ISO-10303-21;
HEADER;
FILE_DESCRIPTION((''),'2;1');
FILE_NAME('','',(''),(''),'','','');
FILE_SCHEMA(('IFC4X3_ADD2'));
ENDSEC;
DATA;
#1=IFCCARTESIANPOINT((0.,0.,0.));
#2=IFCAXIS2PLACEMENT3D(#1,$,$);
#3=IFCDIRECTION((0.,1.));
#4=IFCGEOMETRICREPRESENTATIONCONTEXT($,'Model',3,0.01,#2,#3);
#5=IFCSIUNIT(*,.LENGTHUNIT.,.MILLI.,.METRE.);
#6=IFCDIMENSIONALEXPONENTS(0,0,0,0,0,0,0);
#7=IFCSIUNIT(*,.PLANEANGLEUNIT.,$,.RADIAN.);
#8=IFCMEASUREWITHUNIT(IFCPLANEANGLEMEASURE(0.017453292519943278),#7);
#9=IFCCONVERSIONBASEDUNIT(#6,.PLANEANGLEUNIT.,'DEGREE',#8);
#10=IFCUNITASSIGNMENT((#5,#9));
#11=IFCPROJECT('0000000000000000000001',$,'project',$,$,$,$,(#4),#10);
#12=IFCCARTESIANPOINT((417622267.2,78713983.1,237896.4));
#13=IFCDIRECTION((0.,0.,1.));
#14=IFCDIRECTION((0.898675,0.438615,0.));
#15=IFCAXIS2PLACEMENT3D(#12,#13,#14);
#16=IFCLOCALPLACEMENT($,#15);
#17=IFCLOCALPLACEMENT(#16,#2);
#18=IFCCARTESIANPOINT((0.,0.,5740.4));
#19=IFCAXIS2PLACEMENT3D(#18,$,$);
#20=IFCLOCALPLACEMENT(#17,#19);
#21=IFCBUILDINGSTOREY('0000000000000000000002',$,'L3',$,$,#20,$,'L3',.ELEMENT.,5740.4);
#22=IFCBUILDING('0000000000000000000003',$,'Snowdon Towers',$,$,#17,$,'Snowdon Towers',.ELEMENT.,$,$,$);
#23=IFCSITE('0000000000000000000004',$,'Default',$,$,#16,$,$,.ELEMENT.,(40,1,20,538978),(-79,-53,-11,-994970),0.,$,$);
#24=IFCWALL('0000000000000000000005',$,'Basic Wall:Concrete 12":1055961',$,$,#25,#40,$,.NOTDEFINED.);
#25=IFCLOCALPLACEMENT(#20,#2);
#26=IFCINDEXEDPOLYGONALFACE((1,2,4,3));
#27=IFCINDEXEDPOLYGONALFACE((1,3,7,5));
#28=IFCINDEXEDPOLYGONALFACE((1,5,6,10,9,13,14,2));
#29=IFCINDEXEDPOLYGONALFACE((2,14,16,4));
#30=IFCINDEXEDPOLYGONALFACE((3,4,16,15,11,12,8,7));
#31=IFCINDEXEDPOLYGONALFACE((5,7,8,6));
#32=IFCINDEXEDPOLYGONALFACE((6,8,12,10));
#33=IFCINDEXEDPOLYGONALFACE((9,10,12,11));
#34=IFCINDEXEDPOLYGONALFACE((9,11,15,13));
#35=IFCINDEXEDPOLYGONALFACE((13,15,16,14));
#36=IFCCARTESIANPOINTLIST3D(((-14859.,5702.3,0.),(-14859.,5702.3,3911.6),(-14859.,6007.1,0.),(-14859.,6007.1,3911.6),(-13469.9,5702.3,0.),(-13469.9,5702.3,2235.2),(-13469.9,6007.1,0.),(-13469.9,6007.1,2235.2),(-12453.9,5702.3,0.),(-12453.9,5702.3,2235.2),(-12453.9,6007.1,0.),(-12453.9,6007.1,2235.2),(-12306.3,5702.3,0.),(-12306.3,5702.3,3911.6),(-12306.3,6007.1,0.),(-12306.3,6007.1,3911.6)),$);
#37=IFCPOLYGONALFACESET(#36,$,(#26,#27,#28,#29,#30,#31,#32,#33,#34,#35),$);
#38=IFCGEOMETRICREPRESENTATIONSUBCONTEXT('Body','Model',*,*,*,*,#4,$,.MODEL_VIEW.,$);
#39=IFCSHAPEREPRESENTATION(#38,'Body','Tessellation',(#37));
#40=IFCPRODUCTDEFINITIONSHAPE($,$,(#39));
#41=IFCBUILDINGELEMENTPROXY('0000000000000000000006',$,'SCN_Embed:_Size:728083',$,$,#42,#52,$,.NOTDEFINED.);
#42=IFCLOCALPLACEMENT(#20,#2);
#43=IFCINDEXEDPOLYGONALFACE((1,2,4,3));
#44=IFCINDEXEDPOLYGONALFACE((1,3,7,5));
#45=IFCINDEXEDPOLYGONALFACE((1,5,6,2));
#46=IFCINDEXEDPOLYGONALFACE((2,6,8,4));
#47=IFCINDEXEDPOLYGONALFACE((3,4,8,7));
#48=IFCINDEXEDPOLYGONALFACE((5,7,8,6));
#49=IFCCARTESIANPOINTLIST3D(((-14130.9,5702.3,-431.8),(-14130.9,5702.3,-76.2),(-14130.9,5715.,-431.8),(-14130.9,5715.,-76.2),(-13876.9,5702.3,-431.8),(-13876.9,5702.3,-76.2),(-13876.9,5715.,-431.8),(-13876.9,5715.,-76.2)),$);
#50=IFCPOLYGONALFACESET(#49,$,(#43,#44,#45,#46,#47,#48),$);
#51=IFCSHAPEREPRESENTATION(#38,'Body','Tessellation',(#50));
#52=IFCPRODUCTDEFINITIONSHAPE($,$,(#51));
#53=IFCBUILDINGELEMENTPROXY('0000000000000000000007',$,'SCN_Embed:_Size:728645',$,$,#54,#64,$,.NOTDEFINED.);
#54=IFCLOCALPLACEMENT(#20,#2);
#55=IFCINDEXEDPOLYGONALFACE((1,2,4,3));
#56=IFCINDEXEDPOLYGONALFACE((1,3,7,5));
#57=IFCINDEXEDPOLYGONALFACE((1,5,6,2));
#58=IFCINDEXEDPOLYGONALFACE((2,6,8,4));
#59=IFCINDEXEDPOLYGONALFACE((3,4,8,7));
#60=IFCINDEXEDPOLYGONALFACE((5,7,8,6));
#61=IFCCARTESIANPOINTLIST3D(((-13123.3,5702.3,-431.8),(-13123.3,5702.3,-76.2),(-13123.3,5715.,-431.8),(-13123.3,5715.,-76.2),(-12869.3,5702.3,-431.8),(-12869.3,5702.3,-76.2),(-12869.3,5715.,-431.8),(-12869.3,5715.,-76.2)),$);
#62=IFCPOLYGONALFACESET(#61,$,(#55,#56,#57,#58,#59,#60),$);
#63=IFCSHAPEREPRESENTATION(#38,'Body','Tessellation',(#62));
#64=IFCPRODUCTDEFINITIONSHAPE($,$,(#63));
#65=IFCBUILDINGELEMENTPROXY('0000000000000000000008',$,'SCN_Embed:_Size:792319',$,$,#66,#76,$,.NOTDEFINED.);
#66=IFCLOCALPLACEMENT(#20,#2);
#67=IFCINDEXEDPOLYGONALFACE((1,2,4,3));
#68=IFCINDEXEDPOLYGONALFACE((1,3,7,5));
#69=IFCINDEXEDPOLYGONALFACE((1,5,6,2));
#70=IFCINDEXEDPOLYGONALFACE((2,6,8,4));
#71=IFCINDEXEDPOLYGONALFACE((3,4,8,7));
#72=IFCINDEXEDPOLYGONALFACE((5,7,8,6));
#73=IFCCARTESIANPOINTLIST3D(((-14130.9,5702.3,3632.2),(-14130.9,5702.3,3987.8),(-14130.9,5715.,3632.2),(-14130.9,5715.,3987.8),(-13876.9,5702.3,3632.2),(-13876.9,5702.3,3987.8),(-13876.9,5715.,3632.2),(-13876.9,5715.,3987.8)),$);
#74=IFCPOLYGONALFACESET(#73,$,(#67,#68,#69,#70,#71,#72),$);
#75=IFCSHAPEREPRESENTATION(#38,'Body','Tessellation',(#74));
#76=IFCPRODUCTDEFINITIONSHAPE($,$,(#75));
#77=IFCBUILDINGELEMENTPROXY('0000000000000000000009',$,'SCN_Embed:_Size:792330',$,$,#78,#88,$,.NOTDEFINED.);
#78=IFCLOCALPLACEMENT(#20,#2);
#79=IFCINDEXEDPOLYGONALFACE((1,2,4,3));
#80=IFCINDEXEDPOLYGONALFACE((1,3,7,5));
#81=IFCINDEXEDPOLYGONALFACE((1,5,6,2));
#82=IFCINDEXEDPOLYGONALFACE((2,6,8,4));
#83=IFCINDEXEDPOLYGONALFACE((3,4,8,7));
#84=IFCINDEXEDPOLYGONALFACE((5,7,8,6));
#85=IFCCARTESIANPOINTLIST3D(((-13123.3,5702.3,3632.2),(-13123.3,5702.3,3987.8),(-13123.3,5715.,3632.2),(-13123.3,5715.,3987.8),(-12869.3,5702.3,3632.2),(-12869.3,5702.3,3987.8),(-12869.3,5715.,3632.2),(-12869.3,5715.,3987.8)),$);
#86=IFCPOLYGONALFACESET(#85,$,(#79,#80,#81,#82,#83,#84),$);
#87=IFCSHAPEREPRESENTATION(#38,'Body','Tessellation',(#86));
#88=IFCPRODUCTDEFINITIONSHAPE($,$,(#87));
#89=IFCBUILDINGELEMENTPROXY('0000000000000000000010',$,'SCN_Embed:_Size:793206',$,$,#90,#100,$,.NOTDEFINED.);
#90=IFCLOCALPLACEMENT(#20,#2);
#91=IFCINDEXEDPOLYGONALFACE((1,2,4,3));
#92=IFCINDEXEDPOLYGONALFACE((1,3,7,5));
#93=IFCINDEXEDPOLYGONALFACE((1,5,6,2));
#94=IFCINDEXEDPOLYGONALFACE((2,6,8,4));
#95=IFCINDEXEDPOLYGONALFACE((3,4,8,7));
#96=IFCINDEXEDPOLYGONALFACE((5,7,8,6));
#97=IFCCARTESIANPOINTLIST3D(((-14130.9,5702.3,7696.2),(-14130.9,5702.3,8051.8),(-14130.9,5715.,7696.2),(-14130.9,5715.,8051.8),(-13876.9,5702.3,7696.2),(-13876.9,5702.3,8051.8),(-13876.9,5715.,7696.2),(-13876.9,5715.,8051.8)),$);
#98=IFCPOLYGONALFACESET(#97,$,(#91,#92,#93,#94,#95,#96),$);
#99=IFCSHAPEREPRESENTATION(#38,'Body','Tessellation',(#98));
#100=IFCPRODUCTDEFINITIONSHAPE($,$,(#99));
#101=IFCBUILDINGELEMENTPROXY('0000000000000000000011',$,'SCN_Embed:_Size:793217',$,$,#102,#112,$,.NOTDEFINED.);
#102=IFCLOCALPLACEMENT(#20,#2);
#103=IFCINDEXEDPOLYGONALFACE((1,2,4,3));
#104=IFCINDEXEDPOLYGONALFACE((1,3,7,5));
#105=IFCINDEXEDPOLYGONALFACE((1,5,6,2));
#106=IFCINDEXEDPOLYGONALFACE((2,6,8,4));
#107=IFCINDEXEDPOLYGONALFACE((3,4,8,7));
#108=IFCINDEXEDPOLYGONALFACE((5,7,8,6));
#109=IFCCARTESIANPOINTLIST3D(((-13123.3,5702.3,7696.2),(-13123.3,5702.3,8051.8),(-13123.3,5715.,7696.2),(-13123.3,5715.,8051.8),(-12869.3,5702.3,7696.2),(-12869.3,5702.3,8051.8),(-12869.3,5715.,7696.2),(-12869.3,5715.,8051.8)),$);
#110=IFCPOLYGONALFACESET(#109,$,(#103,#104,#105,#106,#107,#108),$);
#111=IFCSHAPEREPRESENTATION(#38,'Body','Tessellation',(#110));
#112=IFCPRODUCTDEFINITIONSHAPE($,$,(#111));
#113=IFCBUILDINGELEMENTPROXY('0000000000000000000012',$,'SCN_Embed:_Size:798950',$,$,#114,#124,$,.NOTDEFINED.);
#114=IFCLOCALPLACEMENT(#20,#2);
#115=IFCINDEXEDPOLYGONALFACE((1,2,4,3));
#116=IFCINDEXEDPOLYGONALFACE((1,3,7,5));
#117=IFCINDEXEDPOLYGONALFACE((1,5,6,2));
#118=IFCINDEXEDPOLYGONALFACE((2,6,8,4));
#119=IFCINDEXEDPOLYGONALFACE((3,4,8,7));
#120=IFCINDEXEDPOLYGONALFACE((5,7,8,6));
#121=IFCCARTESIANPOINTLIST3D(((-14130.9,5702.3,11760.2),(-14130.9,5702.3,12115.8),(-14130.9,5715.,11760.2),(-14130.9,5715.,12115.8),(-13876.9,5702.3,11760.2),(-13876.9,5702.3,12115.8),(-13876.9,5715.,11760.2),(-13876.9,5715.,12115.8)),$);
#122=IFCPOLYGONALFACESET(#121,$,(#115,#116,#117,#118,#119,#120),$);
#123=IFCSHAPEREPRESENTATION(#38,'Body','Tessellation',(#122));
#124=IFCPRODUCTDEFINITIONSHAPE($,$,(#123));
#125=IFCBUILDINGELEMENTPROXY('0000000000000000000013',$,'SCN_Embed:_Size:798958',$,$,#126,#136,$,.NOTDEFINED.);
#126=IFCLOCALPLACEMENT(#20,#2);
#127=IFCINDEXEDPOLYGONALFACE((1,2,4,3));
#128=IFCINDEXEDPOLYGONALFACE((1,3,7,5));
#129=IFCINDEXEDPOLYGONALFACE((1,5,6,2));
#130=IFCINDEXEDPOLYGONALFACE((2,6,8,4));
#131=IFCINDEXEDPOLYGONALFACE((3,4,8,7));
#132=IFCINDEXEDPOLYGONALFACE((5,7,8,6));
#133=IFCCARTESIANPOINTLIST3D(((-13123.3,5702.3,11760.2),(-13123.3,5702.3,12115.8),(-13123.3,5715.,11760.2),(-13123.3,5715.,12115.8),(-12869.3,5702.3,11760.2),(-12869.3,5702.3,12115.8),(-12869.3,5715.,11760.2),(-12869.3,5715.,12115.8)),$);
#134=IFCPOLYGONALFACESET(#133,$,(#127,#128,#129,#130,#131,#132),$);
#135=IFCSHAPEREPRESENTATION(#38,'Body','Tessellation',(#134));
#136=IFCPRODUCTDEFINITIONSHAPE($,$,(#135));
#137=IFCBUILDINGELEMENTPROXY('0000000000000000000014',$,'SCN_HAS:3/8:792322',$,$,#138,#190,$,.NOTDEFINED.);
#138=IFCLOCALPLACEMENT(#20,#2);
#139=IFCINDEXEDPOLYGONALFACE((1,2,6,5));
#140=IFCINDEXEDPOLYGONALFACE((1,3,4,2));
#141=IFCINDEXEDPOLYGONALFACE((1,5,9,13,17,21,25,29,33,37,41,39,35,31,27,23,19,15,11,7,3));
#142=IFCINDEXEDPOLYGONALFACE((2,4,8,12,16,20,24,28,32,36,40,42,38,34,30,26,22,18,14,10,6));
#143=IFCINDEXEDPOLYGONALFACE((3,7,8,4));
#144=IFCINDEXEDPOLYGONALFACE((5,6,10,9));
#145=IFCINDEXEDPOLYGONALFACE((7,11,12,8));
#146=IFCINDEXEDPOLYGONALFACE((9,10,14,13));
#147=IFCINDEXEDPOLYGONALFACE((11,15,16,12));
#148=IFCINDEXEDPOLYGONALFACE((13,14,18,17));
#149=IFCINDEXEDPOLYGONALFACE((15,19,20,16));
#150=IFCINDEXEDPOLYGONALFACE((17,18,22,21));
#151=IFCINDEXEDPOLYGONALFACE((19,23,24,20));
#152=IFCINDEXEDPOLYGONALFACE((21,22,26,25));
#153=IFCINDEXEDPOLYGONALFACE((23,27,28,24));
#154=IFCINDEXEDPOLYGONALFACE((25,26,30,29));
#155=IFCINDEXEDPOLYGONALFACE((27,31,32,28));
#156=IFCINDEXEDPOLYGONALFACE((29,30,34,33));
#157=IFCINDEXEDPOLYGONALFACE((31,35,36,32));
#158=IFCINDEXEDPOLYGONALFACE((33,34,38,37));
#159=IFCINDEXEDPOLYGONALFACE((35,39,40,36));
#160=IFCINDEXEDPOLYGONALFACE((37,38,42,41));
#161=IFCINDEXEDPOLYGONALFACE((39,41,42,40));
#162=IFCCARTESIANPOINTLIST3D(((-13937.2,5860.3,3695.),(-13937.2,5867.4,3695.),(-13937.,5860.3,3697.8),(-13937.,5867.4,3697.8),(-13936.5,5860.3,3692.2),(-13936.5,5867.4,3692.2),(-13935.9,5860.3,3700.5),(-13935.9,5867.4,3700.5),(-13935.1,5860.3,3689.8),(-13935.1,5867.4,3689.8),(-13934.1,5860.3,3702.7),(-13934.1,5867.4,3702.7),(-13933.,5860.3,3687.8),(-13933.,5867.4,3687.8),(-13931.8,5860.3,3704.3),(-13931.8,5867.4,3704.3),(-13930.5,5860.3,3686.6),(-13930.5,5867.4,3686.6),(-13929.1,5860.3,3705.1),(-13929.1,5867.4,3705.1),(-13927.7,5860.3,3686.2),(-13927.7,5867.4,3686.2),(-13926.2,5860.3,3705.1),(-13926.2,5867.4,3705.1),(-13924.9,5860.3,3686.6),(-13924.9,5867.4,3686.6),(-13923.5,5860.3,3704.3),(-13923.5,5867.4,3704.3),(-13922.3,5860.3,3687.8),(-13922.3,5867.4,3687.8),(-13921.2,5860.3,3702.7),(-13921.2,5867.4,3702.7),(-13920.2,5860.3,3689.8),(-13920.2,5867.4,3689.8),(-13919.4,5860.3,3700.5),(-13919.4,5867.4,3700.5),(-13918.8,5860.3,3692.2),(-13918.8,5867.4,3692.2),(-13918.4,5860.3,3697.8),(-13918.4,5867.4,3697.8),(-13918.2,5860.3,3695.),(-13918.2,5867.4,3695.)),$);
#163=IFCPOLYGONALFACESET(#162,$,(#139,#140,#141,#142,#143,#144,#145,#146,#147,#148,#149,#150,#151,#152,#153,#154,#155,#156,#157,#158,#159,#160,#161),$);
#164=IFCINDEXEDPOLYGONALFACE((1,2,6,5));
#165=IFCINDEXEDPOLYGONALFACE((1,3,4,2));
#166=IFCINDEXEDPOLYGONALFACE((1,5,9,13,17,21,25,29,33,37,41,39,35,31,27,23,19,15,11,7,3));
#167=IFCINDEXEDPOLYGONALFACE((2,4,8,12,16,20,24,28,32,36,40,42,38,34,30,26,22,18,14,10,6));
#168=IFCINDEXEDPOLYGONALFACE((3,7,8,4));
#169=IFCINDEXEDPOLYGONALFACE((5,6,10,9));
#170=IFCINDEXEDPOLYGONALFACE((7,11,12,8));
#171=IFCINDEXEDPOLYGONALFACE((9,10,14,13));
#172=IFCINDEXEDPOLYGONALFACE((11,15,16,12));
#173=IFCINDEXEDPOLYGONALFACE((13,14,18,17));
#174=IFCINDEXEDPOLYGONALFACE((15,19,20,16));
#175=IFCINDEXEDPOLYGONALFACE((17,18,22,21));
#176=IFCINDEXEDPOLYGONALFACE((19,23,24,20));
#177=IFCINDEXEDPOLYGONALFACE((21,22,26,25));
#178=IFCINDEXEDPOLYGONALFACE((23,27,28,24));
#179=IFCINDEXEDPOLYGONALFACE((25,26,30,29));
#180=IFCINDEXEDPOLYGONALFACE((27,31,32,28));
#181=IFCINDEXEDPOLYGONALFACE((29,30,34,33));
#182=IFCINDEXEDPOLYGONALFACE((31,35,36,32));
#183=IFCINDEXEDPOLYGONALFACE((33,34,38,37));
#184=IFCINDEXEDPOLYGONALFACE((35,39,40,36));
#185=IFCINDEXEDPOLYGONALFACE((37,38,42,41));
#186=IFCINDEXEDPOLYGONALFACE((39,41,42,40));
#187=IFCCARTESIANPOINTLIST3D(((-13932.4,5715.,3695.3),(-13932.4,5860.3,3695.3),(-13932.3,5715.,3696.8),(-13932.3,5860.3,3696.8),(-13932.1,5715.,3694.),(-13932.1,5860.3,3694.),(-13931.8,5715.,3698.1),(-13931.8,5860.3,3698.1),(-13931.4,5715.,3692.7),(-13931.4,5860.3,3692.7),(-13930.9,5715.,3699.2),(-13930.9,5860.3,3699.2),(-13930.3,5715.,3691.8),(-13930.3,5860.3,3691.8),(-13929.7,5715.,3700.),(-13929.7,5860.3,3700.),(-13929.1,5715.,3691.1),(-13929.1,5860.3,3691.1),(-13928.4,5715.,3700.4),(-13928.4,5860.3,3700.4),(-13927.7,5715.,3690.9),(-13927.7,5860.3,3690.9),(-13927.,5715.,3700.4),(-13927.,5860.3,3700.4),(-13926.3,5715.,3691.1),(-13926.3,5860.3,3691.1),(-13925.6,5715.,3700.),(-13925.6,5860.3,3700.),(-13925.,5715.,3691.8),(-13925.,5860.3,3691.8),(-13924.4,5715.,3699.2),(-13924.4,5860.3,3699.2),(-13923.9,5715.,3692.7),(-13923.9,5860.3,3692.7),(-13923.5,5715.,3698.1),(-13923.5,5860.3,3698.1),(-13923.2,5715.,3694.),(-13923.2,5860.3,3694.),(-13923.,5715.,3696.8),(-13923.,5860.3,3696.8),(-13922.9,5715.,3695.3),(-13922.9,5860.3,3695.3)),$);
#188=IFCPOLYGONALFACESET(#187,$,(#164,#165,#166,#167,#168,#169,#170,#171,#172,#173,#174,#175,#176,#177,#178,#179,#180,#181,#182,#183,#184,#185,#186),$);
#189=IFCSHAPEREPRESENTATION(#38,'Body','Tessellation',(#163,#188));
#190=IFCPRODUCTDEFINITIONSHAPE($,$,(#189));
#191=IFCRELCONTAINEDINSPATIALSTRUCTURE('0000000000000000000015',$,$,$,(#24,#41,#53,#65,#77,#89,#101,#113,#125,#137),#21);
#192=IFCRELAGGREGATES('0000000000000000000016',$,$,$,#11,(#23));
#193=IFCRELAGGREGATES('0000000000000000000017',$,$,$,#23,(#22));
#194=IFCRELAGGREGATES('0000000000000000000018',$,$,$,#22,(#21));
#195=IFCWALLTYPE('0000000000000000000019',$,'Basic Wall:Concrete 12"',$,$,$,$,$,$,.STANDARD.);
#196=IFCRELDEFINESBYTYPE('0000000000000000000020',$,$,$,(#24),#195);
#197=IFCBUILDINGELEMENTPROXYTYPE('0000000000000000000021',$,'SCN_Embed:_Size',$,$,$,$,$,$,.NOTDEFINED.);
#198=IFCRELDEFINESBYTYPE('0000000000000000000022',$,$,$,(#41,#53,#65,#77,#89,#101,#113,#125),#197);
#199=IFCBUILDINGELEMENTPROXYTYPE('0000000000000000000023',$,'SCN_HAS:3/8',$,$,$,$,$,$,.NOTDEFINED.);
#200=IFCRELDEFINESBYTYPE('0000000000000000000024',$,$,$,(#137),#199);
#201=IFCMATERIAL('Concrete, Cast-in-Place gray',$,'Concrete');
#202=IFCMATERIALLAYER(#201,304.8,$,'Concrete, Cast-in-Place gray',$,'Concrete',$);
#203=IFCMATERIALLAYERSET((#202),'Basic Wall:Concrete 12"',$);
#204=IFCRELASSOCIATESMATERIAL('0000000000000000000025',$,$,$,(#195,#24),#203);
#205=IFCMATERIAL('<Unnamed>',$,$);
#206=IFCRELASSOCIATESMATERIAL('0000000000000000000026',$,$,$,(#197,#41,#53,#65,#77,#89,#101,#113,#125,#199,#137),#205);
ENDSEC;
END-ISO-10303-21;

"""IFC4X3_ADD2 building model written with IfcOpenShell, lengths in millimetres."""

from ifc_helpers import new_model, entity, si_unit, converted_unit, direction, frame, frame_2d, origin, place, context, subcontext, project, spatial, rectangle, circle, extrude, source, transform, mapped, material, layer, layer_set, type_object, type_shapes, element, save


model = new_model("IFC4X3_ADD2")

# Units and contexts
model_context = context("Model", 3, precision=0.01, world=origin(), true_north=direction((0.0, 1.0)))
body_context = subcontext(model_context, "Body", "Model", "MODEL_VIEW")
ifc_project = project(units=[si_unit("LENGTHUNIT", "METRE", prefix="MILLI"), converted_unit("PLANEANGLEUNIT", "DEGREE", entity("IfcPlaneAngleMeasure", 0.017453292519943278), si_unit("PLANEANGLEUNIT", "RADIAN"), dimensions=[0, 0, 0, 0, 0, 0, 0])], contexts=[model_context])

# Site, building, storey
site_placement = place(None, frame((417622267.2, 78713983.1, 237896.4), z_axis=(0.0, 0.0, 1.0), x_axis=(0.898675, 0.438615, 0.0)))
site = spatial("IfcSite", under=ifc_project, at=site_placement, Name="Default", CompositionType="ELEMENT", RefLatitude=(40, 1, 20, 538978), RefLongitude=(-79, -53, -11, -994970), RefElevation=0.0)
building_placement = place(site_placement, origin())
building = spatial("IfcBuilding", under=site, at=building_placement, Name="Snowdon Towers", LongName="Snowdon Towers", CompositionType="ELEMENT")
storey_placement = place(building_placement, frame((0.0, 0.0, 5740.4)))
storey = spatial("IfcBuildingStorey", under=building, at=storey_placement, Name="L3", LongName="L3", CompositionType="ELEMENT", Elevation=5740.4)

# Shared definitions
ifc_material_1 = material(Name="Concrete, Cast-in-Place gray", Category="Concrete")
ifc_layer = layer(ifc_material_1, 304.8, Name="Concrete, Cast-in-Place gray", Category="Concrete")
ifc_layer_set = layer_set([ifc_layer], Name="Basic Wall:Concrete 12\"")
wall_type = type_object("IfcWallType", Name="Basic Wall:Concrete 12\"", PredefinedType="STANDARD", material=ifc_layer_set)

# Wall, opening
wall_1_placement = place(storey_placement, frame((-12306.3, 5854.7, 0.0), z_axis=(0.0, 0.0, 1.0), x_axis=(-1.0, 0.0, 0.0)))
wall_1 = element("IfcWall", 1, at=wall_1_placement, inside=storey, type_object=wall_type, material=ifc_layer_set, Name="Basic Wall:Concrete 12\":1055961", PredefinedType="NOTDEFINED", context=body_context, shape_type="SweptSolid", body=[
    extrude(rectangle(XDim=2552.7, YDim=304.8, at=frame_2d((1276.3, 0.0), x_axis=(-1.0, 0.0))), origin(), (0.0, 0.0, 1.0), 3911.6),
])
opening_placement = place(wall_1_placement, origin())
element("IfcOpeningElement", 2, at=opening_placement, cuts=wall_1, PredefinedType="OPENING", context=body_context, shape_type="SweptSolid", body=[
    extrude(rectangle(XDim=2235.2, YDim=1016.0, at=frame_2d((0.0, 0.0), x_axis=(0.0, 1.0))), frame((655.6, 152.4, 1117.6), z_axis=(0.0, -1.0, 0.0), x_axis=(1.0, 0.0, 0.0)), (0.0, 0.0, 1.0), 304.8),
])

# Building element proxies
ifc_material_2 = material(Name="<Unnamed>")
building_element_proxy_type_1 = type_object("IfcBuildingElementProxyType", Name="SCN_Embed:_Size", PredefinedType="NOTDEFINED", material=ifc_material_2)
shared_shape_1 = source(origin(), body_context, "Body", "SweptSolid", [
    extrude(rectangle(XDim=254.0, YDim=355.6, at=frame_2d((0.0, 0.0), x_axis=(1.0, 0.0))), frame((0.0, 0.0, -12.7), z_axis=(0.0, 0.0, 1.0), x_axis=(-1.0, 0.0, 0.0)), (0.0, 0.0, 1.0), 12.7),
])
type_shapes(building_element_proxy_type_1, [shared_shape_1])
for number, where, z_axis, x_axis, name in (
    (3, (-14003.9, 5702.3, -254.0), (0.0, -1.0, 0.0), (1.0, 0.0, 0.0), "SCN_Embed:_Size:728083"),
    (4, (-12996.3, 5702.3, -254.0), (0.0, -1.0, 0.0), (1.0, 0.0, 0.0), "SCN_Embed:_Size:728645"),
    (5, (-14003.9, 5702.3, 3810.0), (0.0, -1.0, 0.0), (1.0, 0.0, 0.0), "SCN_Embed:_Size:792319"),
    (6, (-12996.3, 5702.3, 3810.0), (0.0, -1.0, 0.0), (1.0, 0.0, 0.0), "SCN_Embed:_Size:792330"),
    (7, (-14003.9, 5702.3, 7874.0), (0.0, -1.0, 0.0), (1.0, 0.0, 0.0), "SCN_Embed:_Size:793206"),
    (8, (-12996.3, 5702.3, 7874.0), (0.0, -1.0, 0.0), (1.0, 0.0, 0.0), "SCN_Embed:_Size:793217"),
    (9, (-14003.9, 5702.3, 11938.0), (0.0, -1.0, 0.0), (1.0, 0.0, 0.0), "SCN_Embed:_Size:798950"),
    (10, (-12996.3, 5702.3, 11938.0), (0.0, -1.0, 0.0), (1.0, 0.0, 0.0), "SCN_Embed:_Size:798958"),
):
    element("IfcBuildingElementProxy", number, at=place(storey_placement, frame(where, z_axis=z_axis, x_axis=x_axis)), inside=storey, type_object=building_element_proxy_type_1, material=ifc_material_2, Name=name, PredefinedType="NOTDEFINED", context=body_context, shape_type="MappedRepresentation", body=[
        mapped(shared_shape_1, transform((0.0, 0.0, 0.0), scale=1.0)),
    ])
building_element_proxy_type_2 = type_object("IfcBuildingElementProxyType", Name="SCN_HAS:3/8", PredefinedType="NOTDEFINED", material=ifc_material_2)
shared_shape_2 = source(origin(), body_context, "Body", "SweptSolid", [
    extrude(circle(Radius=9.5, at=frame_2d((0.0, 0.0), x_axis=(1.0, 0.0))), frame((0.0, 0.0, -152.4), z_axis=(0.0, 0.0, 1.0), x_axis=(0.0, -1.0, 0.0)), (0.0, 0.0, 1.0), 7.1),
    extrude(circle(Radius=4.8, at=frame_2d((0.0, 0.0), x_axis=(1.0, 0.0))), frame((0.0, 0.0, -145.3), z_axis=(0.0, 0.0, 1.0), x_axis=(0.0, -1.0, 0.0)), (0.0, 0.0, 1.0), 145.3),
])
type_shapes(building_element_proxy_type_2, [shared_shape_2])
for number, where, z_axis, x_axis, name in (
    (11, (-13927.7, 5715.0, 3695.7), (0.0, -1.0, 0.0), (1.0, 0.0, 0.0), "SCN_HAS:3/8:792322"),
):
    element("IfcBuildingElementProxy", number, at=place(storey_placement, frame(where, z_axis=z_axis, x_axis=x_axis)), inside=storey, type_object=building_element_proxy_type_2, material=ifc_material_2, Name=name, PredefinedType="NOTDEFINED", context=body_context, shape_type="MappedRepresentation", body=[
        mapped(shared_shape_2, transform((0.0, 0.0, 0.0), scale=1.0)),
    ])

save(model, "model.ifc")
